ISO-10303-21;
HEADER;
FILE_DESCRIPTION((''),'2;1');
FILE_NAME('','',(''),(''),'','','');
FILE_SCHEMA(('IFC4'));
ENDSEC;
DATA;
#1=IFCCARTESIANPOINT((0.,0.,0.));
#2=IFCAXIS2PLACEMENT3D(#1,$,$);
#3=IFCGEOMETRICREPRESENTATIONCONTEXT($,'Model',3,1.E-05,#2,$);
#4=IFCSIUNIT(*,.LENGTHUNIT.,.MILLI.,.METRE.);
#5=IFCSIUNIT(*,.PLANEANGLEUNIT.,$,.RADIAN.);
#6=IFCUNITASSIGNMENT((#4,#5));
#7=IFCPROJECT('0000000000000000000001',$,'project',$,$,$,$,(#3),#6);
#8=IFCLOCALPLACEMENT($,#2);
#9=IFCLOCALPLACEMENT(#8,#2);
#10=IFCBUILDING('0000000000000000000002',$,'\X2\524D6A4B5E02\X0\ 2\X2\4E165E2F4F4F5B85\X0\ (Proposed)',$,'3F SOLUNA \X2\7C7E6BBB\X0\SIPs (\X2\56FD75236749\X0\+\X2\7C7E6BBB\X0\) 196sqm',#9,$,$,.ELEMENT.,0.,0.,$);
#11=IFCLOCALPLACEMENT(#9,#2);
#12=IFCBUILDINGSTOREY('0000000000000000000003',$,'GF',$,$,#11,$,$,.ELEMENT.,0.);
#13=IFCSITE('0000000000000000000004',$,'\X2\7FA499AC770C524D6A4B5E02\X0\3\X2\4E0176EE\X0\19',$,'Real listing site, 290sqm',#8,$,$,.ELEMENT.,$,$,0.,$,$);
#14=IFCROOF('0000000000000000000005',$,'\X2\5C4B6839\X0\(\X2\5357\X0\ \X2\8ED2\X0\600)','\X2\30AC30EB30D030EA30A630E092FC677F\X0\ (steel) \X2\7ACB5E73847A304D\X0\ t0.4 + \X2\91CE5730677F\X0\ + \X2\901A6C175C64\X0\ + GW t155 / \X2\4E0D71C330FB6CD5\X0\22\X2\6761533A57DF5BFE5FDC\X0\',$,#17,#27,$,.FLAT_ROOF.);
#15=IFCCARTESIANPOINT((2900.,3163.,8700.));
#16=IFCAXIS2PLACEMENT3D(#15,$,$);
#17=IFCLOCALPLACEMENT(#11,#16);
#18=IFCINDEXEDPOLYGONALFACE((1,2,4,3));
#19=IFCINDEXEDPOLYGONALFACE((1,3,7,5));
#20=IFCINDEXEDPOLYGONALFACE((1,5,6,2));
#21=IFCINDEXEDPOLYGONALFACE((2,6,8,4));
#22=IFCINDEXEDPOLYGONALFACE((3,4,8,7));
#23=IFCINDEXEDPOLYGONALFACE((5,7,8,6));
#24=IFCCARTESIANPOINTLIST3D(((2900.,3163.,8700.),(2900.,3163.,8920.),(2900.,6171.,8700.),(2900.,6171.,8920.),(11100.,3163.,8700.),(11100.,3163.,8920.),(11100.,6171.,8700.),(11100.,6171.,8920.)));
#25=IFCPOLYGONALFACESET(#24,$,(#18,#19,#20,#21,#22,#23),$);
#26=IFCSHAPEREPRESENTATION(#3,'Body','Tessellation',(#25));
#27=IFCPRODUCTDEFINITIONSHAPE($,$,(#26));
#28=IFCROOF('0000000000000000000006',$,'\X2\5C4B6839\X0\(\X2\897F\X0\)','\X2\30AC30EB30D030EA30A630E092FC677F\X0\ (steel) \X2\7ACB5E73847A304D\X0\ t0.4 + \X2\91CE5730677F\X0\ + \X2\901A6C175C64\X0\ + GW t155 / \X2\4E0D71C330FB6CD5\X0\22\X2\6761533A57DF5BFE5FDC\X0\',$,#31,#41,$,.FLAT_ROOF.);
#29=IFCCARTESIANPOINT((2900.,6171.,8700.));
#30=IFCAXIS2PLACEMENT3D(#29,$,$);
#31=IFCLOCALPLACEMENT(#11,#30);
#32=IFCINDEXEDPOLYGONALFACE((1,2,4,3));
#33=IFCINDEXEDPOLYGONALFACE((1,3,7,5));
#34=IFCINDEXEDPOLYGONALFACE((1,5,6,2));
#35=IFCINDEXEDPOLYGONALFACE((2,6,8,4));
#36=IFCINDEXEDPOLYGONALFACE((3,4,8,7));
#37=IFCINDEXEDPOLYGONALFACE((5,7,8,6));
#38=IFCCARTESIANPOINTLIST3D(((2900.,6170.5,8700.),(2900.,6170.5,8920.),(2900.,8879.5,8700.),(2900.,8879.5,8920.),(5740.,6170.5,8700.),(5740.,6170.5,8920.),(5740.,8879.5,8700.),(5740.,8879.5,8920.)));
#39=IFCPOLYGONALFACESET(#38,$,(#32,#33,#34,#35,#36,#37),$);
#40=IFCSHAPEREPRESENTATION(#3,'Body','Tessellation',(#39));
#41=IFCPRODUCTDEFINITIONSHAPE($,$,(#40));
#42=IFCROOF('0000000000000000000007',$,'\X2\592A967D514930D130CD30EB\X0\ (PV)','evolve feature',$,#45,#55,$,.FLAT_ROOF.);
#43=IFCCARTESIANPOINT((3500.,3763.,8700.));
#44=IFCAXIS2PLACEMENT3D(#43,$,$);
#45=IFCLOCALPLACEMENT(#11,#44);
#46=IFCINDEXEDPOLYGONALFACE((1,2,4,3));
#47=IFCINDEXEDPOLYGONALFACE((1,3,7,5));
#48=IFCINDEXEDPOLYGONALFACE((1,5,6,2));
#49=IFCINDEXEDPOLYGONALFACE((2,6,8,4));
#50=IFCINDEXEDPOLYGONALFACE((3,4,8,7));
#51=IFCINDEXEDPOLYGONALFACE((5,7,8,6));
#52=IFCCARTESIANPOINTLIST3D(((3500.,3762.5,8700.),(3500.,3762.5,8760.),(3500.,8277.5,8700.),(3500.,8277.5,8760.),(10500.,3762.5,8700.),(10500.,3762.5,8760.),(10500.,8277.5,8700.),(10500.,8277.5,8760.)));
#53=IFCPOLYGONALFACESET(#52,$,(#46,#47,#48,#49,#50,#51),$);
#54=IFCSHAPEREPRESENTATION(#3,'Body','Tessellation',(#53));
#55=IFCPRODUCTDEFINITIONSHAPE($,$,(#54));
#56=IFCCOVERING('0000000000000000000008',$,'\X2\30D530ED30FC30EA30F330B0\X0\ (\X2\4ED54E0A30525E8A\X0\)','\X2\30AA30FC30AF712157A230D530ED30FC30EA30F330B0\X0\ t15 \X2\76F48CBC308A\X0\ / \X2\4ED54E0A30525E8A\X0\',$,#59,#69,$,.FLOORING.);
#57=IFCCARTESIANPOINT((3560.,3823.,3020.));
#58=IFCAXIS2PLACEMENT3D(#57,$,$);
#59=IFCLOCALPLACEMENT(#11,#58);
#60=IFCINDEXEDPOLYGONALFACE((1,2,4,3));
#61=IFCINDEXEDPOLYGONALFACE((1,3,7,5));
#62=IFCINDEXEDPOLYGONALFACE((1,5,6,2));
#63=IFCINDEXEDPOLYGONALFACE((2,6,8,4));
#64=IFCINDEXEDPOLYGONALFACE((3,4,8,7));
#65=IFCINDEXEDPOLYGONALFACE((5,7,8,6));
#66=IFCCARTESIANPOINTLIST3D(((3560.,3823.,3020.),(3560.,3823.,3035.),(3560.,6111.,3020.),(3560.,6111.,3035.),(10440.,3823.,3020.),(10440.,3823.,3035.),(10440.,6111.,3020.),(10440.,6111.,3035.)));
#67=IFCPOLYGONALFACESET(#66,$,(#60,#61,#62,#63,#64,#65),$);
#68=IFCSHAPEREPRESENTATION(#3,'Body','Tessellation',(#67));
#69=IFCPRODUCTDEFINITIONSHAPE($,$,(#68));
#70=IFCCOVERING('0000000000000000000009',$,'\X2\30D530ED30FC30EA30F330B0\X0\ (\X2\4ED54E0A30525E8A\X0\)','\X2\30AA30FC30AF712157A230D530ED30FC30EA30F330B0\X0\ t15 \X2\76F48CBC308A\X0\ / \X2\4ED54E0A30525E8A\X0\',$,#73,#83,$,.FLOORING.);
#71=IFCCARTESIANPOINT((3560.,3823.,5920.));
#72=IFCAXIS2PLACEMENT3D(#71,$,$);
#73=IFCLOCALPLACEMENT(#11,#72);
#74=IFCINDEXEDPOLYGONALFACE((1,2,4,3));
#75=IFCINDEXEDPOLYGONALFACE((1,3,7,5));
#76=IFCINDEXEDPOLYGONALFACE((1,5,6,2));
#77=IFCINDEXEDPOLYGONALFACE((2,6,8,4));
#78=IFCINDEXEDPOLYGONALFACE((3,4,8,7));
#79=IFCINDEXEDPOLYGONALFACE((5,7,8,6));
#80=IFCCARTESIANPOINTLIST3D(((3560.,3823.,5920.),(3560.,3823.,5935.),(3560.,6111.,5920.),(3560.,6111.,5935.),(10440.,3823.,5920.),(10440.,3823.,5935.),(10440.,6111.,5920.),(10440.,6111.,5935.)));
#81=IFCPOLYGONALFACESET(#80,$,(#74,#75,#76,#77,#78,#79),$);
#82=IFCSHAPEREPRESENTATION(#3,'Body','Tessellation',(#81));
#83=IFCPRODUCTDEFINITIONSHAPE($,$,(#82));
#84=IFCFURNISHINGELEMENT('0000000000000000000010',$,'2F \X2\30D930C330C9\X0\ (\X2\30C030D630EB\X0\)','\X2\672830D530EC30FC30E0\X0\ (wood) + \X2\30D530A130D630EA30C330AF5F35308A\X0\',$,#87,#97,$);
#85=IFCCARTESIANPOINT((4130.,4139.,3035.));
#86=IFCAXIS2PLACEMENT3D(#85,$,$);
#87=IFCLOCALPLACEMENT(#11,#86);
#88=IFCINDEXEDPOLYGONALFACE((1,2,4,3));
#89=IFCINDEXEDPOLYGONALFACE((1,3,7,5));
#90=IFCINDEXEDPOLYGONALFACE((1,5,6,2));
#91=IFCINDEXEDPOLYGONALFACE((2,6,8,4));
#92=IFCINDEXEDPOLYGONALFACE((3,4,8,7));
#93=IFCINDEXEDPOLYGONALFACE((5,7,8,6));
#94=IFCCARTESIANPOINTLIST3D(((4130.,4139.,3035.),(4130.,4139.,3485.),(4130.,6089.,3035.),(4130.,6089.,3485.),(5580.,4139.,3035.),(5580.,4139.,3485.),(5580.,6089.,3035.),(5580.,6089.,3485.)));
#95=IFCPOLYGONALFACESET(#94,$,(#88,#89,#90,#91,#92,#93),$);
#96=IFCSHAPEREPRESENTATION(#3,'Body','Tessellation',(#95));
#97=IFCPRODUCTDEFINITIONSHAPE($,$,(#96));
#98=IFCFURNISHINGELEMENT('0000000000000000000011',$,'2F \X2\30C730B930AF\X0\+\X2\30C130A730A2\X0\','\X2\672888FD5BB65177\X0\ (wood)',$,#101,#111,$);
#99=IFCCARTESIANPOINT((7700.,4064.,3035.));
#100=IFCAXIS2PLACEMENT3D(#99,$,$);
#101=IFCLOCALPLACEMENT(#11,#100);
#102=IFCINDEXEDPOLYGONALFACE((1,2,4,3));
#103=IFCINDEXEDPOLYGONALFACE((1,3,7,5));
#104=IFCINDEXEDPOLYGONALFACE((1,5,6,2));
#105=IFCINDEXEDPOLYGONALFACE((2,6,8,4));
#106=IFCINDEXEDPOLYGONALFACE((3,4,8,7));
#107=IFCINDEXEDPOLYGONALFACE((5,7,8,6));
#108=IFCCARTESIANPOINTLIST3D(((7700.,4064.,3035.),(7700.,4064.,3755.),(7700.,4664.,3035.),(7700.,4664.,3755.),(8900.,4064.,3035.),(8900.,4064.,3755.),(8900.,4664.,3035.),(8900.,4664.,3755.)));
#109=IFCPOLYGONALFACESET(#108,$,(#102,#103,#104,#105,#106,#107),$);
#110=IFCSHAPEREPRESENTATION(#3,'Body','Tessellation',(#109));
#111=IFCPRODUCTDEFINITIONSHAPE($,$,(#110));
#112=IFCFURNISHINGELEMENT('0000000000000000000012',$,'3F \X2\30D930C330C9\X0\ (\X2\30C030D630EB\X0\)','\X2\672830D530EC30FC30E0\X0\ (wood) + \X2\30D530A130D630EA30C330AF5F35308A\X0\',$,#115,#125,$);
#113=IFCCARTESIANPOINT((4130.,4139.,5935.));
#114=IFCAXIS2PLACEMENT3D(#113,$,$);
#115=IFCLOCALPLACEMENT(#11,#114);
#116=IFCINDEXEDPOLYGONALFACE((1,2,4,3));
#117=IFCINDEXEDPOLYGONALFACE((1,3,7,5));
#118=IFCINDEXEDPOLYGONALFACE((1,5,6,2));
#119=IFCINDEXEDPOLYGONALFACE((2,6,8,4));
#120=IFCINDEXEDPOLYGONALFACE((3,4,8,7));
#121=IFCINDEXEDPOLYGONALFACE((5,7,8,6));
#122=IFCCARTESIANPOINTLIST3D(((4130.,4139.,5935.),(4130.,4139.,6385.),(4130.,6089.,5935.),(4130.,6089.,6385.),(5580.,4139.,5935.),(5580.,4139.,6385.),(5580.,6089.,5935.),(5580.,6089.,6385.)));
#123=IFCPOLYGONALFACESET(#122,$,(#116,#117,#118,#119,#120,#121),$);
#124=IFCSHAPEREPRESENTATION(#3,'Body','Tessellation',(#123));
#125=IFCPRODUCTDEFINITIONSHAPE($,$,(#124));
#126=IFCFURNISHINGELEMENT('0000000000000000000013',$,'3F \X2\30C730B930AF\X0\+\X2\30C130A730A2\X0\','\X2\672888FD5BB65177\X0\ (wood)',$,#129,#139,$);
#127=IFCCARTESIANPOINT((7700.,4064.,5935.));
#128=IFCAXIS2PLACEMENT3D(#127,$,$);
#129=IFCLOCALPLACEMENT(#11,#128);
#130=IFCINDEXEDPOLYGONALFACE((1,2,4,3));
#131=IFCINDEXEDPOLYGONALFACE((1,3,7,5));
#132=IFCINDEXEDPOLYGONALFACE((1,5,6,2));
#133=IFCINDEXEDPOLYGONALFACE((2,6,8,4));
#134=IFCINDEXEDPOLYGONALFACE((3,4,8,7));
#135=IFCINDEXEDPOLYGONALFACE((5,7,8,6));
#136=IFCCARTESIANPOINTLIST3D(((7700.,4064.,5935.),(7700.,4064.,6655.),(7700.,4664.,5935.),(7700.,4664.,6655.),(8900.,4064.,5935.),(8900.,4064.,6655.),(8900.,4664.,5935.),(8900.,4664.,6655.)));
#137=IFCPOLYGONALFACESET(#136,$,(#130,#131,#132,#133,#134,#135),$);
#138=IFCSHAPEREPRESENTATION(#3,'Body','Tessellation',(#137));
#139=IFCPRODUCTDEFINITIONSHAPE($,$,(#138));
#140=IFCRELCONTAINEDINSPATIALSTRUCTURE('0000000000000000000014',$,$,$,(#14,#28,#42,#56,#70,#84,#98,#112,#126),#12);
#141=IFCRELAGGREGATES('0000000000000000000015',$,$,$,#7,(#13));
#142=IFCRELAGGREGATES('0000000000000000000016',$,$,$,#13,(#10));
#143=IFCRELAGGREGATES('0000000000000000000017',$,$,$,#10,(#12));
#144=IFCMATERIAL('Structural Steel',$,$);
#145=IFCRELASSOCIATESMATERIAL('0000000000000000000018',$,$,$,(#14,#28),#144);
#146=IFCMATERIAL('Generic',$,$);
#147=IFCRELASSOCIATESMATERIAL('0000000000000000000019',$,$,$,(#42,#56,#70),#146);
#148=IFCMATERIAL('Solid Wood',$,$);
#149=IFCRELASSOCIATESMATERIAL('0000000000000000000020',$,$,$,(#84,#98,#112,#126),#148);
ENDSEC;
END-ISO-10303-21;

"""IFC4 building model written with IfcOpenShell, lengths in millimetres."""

from ifc_helpers import new_model, si_unit, frame, frame_2d, origin, place, context, project, spatial, rectangle, extrude, material, element, save


model = new_model("IFC4")

# Units and contexts
model_context = context("Model", 3, precision=1e-05, world=origin())
ifc_project = project(units=[si_unit("LENGTHUNIT", "METRE", prefix="MILLI"), si_unit("PLANEANGLEUNIT", "RADIAN")], contexts=[model_context])

# Site, building, storey
site_placement = place(None, origin())
site = spatial("IfcSite", under=ifc_project, at=site_placement, Name="群馬県前橋市3丁目19", ObjectType="Real listing site, 290sqm", CompositionType="ELEMENT", RefElevation=0.0)
building_placement = place(site_placement, origin())
building = spatial("IfcBuilding", under=site, at=building_placement, Name="前橋市 2世帯住宅 (Proposed)", ObjectType="3F SOLUNA 籾殻SIPs (国産杉+籾殻) 196sqm", CompositionType="ELEMENT", ElevationOfRefHeight=0.0, ElevationOfTerrain=0.0)
storey_placement = place(building_placement, origin())
storey = spatial("IfcBuildingStorey", under=building, at=storey_placement, Name="GF", CompositionType="ELEMENT", Elevation=0.0)

# Shared definitions
ifc_material_1 = material(Name="Solid Wood")

# Roofs
ifc_material_2 = material(Name="Structural Steel")
roof_1_placement = place(storey_placement, frame((2900.0, 3163.0, 8700.0)))
element("IfcRoof", 1, at=roof_1_placement, inside=storey, material=ifc_material_2, Name="屋根(南 軒600)", Description="ガルバリウム鋼板 (steel) 立平葺き t0.4 + 野地板 + 通気層 + GW t155 / 不燃・法22条区域対応", PredefinedType="FLAT_ROOF", context=model_context, shape_type="SweptSolid", body=[
    extrude(rectangle(XDim=8200.0, YDim=3008.0, at=frame_2d((4100.0, 1504.0))), frame((2900.0, 3163.0, 8700.0)), (0.0, 0.0, 1.0), 220.0),
])
roof_2_placement = place(storey_placement, frame((2900.0, 6171.0, 8700.0)))
element("IfcRoof", 2, at=roof_2_placement, inside=storey, material=ifc_material_2, Name="屋根(西)", Description="ガルバリウム鋼板 (steel) 立平葺き t0.4 + 野地板 + 通気層 + GW t155 / 不燃・法22条区域対応", PredefinedType="FLAT_ROOF", context=model_context, shape_type="SweptSolid", body=[
    extrude(rectangle(XDim=2840.0, YDim=2709.0, at=frame_2d((1420.0, 1354.0))), frame((2900.0, 6171.0, 8700.0)), (0.0, 0.0, 1.0), 220.0),
])
ifc_material_3 = material(Name="Generic")
roof_3_placement = place(storey_placement, frame((3500.0, 3763.0, 8700.0)))
element("IfcRoof", 3, at=roof_3_placement, inside=storey, material=ifc_material_3, Name="太陽光パネル (PV)", Description="evolve feature", PredefinedType="FLAT_ROOF", context=model_context, shape_type="SweptSolid", body=[
    extrude(rectangle(XDim=7000.0, YDim=4515.0, at=frame_2d((3500.0, 2257.0))), frame((3500.0, 3763.0, 8700.0)), (0.0, 0.0, 1.0), 60.0),
])

# Coverings
covering_1_placement = place(storey_placement, frame((3560.0, 3823.0, 3020.0)))
element("IfcCovering", 4, at=covering_1_placement, inside=storey, material=ifc_material_3, Name="フローリング (仕上げ床)", Description="オーク無垢フローリング t15 直貼り / 仕上げ床", PredefinedType="FLOORING", context=model_context, shape_type="SweptSolid", body=[
    extrude(rectangle(XDim=6880.0, YDim=2288.0, at=frame_2d((3440.0, 1144.0))), frame((3560.0, 3823.0, 3020.0)), (0.0, 0.0, 1.0), 15.0),
])
covering_2_placement = place(storey_placement, frame((3560.0, 3823.0, 5920.0)))
element("IfcCovering", 5, at=covering_2_placement, inside=storey, material=ifc_material_3, Name="フローリング (仕上げ床)", Description="オーク無垢フローリング t15 直貼り / 仕上げ床", PredefinedType="FLOORING", context=model_context, shape_type="SweptSolid", body=[
    extrude(rectangle(XDim=6880.0, YDim=2288.0, at=frame_2d((3440.0, 1144.0))), frame((3560.0, 3823.0, 5920.0)), (0.0, 0.0, 1.0), 15.0),
])

# Furnishing elements
furnishing_1_placement = place(storey_placement, frame((4130.0, 4139.0, 3035.0)))
element("IfcFurnishingElement", 6, at=furnishing_1_placement, inside=storey, material=ifc_material_1, Name="2F ベッド (ダブル)", Description="木フレーム (wood) + ファブリック張り", context=model_context, shape_type="SweptSolid", body=[
    extrude(rectangle(XDim=1450.0, YDim=1950.0, at=frame_2d((725.0, 975.0))), frame((4130.0, 4139.0, 3035.0)), (0.0, 0.0, 1.0), 450.0),
])
furnishing_2_placement = place(storey_placement, frame((7700.0, 4064.0, 3035.0)))
element("IfcFurnishingElement", 7, at=furnishing_2_placement, inside=storey, material=ifc_material_1, Name="2F デスク+チェア", Description="木製家具 (wood)", context=model_context, shape_type="SweptSolid", body=[
    extrude(rectangle(XDim=1200.0, YDim=600.0, at=frame_2d((600.0, 300.0))), frame((7700.0, 4064.0, 3035.0)), (0.0, 0.0, 1.0), 720.0),
])
furnishing_3_placement = place(storey_placement, frame((4130.0, 4139.0, 5935.0)))
element("IfcFurnishingElement", 8, at=furnishing_3_placement, inside=storey, material=ifc_material_1, Name="3F ベッド (ダブル)", Description="木フレーム (wood) + ファブリック張り", context=model_context, shape_type="SweptSolid", body=[
    extrude(rectangle(XDim=1450.0, YDim=1950.0, at=frame_2d((725.0, 975.0))), frame((4130.0, 4139.0, 5935.0)), (0.0, 0.0, 1.0), 450.0),
])
furnishing_4_placement = place(storey_placement, frame((7700.0, 4064.0, 5935.0)))
element("IfcFurnishingElement", 9, at=furnishing_4_placement, inside=storey, material=ifc_material_1, Name="3F デスク+チェア", Description="木製家具 (wood)", context=model_context, shape_type="SweptSolid", body=[
    extrude(rectangle(XDim=1200.0, YDim=600.0, at=frame_2d((600.0, 300.0))), frame((7700.0, 4064.0, 5935.0)), (0.0, 0.0, 1.0), 720.0),
])

save(model, "model.ifc")
